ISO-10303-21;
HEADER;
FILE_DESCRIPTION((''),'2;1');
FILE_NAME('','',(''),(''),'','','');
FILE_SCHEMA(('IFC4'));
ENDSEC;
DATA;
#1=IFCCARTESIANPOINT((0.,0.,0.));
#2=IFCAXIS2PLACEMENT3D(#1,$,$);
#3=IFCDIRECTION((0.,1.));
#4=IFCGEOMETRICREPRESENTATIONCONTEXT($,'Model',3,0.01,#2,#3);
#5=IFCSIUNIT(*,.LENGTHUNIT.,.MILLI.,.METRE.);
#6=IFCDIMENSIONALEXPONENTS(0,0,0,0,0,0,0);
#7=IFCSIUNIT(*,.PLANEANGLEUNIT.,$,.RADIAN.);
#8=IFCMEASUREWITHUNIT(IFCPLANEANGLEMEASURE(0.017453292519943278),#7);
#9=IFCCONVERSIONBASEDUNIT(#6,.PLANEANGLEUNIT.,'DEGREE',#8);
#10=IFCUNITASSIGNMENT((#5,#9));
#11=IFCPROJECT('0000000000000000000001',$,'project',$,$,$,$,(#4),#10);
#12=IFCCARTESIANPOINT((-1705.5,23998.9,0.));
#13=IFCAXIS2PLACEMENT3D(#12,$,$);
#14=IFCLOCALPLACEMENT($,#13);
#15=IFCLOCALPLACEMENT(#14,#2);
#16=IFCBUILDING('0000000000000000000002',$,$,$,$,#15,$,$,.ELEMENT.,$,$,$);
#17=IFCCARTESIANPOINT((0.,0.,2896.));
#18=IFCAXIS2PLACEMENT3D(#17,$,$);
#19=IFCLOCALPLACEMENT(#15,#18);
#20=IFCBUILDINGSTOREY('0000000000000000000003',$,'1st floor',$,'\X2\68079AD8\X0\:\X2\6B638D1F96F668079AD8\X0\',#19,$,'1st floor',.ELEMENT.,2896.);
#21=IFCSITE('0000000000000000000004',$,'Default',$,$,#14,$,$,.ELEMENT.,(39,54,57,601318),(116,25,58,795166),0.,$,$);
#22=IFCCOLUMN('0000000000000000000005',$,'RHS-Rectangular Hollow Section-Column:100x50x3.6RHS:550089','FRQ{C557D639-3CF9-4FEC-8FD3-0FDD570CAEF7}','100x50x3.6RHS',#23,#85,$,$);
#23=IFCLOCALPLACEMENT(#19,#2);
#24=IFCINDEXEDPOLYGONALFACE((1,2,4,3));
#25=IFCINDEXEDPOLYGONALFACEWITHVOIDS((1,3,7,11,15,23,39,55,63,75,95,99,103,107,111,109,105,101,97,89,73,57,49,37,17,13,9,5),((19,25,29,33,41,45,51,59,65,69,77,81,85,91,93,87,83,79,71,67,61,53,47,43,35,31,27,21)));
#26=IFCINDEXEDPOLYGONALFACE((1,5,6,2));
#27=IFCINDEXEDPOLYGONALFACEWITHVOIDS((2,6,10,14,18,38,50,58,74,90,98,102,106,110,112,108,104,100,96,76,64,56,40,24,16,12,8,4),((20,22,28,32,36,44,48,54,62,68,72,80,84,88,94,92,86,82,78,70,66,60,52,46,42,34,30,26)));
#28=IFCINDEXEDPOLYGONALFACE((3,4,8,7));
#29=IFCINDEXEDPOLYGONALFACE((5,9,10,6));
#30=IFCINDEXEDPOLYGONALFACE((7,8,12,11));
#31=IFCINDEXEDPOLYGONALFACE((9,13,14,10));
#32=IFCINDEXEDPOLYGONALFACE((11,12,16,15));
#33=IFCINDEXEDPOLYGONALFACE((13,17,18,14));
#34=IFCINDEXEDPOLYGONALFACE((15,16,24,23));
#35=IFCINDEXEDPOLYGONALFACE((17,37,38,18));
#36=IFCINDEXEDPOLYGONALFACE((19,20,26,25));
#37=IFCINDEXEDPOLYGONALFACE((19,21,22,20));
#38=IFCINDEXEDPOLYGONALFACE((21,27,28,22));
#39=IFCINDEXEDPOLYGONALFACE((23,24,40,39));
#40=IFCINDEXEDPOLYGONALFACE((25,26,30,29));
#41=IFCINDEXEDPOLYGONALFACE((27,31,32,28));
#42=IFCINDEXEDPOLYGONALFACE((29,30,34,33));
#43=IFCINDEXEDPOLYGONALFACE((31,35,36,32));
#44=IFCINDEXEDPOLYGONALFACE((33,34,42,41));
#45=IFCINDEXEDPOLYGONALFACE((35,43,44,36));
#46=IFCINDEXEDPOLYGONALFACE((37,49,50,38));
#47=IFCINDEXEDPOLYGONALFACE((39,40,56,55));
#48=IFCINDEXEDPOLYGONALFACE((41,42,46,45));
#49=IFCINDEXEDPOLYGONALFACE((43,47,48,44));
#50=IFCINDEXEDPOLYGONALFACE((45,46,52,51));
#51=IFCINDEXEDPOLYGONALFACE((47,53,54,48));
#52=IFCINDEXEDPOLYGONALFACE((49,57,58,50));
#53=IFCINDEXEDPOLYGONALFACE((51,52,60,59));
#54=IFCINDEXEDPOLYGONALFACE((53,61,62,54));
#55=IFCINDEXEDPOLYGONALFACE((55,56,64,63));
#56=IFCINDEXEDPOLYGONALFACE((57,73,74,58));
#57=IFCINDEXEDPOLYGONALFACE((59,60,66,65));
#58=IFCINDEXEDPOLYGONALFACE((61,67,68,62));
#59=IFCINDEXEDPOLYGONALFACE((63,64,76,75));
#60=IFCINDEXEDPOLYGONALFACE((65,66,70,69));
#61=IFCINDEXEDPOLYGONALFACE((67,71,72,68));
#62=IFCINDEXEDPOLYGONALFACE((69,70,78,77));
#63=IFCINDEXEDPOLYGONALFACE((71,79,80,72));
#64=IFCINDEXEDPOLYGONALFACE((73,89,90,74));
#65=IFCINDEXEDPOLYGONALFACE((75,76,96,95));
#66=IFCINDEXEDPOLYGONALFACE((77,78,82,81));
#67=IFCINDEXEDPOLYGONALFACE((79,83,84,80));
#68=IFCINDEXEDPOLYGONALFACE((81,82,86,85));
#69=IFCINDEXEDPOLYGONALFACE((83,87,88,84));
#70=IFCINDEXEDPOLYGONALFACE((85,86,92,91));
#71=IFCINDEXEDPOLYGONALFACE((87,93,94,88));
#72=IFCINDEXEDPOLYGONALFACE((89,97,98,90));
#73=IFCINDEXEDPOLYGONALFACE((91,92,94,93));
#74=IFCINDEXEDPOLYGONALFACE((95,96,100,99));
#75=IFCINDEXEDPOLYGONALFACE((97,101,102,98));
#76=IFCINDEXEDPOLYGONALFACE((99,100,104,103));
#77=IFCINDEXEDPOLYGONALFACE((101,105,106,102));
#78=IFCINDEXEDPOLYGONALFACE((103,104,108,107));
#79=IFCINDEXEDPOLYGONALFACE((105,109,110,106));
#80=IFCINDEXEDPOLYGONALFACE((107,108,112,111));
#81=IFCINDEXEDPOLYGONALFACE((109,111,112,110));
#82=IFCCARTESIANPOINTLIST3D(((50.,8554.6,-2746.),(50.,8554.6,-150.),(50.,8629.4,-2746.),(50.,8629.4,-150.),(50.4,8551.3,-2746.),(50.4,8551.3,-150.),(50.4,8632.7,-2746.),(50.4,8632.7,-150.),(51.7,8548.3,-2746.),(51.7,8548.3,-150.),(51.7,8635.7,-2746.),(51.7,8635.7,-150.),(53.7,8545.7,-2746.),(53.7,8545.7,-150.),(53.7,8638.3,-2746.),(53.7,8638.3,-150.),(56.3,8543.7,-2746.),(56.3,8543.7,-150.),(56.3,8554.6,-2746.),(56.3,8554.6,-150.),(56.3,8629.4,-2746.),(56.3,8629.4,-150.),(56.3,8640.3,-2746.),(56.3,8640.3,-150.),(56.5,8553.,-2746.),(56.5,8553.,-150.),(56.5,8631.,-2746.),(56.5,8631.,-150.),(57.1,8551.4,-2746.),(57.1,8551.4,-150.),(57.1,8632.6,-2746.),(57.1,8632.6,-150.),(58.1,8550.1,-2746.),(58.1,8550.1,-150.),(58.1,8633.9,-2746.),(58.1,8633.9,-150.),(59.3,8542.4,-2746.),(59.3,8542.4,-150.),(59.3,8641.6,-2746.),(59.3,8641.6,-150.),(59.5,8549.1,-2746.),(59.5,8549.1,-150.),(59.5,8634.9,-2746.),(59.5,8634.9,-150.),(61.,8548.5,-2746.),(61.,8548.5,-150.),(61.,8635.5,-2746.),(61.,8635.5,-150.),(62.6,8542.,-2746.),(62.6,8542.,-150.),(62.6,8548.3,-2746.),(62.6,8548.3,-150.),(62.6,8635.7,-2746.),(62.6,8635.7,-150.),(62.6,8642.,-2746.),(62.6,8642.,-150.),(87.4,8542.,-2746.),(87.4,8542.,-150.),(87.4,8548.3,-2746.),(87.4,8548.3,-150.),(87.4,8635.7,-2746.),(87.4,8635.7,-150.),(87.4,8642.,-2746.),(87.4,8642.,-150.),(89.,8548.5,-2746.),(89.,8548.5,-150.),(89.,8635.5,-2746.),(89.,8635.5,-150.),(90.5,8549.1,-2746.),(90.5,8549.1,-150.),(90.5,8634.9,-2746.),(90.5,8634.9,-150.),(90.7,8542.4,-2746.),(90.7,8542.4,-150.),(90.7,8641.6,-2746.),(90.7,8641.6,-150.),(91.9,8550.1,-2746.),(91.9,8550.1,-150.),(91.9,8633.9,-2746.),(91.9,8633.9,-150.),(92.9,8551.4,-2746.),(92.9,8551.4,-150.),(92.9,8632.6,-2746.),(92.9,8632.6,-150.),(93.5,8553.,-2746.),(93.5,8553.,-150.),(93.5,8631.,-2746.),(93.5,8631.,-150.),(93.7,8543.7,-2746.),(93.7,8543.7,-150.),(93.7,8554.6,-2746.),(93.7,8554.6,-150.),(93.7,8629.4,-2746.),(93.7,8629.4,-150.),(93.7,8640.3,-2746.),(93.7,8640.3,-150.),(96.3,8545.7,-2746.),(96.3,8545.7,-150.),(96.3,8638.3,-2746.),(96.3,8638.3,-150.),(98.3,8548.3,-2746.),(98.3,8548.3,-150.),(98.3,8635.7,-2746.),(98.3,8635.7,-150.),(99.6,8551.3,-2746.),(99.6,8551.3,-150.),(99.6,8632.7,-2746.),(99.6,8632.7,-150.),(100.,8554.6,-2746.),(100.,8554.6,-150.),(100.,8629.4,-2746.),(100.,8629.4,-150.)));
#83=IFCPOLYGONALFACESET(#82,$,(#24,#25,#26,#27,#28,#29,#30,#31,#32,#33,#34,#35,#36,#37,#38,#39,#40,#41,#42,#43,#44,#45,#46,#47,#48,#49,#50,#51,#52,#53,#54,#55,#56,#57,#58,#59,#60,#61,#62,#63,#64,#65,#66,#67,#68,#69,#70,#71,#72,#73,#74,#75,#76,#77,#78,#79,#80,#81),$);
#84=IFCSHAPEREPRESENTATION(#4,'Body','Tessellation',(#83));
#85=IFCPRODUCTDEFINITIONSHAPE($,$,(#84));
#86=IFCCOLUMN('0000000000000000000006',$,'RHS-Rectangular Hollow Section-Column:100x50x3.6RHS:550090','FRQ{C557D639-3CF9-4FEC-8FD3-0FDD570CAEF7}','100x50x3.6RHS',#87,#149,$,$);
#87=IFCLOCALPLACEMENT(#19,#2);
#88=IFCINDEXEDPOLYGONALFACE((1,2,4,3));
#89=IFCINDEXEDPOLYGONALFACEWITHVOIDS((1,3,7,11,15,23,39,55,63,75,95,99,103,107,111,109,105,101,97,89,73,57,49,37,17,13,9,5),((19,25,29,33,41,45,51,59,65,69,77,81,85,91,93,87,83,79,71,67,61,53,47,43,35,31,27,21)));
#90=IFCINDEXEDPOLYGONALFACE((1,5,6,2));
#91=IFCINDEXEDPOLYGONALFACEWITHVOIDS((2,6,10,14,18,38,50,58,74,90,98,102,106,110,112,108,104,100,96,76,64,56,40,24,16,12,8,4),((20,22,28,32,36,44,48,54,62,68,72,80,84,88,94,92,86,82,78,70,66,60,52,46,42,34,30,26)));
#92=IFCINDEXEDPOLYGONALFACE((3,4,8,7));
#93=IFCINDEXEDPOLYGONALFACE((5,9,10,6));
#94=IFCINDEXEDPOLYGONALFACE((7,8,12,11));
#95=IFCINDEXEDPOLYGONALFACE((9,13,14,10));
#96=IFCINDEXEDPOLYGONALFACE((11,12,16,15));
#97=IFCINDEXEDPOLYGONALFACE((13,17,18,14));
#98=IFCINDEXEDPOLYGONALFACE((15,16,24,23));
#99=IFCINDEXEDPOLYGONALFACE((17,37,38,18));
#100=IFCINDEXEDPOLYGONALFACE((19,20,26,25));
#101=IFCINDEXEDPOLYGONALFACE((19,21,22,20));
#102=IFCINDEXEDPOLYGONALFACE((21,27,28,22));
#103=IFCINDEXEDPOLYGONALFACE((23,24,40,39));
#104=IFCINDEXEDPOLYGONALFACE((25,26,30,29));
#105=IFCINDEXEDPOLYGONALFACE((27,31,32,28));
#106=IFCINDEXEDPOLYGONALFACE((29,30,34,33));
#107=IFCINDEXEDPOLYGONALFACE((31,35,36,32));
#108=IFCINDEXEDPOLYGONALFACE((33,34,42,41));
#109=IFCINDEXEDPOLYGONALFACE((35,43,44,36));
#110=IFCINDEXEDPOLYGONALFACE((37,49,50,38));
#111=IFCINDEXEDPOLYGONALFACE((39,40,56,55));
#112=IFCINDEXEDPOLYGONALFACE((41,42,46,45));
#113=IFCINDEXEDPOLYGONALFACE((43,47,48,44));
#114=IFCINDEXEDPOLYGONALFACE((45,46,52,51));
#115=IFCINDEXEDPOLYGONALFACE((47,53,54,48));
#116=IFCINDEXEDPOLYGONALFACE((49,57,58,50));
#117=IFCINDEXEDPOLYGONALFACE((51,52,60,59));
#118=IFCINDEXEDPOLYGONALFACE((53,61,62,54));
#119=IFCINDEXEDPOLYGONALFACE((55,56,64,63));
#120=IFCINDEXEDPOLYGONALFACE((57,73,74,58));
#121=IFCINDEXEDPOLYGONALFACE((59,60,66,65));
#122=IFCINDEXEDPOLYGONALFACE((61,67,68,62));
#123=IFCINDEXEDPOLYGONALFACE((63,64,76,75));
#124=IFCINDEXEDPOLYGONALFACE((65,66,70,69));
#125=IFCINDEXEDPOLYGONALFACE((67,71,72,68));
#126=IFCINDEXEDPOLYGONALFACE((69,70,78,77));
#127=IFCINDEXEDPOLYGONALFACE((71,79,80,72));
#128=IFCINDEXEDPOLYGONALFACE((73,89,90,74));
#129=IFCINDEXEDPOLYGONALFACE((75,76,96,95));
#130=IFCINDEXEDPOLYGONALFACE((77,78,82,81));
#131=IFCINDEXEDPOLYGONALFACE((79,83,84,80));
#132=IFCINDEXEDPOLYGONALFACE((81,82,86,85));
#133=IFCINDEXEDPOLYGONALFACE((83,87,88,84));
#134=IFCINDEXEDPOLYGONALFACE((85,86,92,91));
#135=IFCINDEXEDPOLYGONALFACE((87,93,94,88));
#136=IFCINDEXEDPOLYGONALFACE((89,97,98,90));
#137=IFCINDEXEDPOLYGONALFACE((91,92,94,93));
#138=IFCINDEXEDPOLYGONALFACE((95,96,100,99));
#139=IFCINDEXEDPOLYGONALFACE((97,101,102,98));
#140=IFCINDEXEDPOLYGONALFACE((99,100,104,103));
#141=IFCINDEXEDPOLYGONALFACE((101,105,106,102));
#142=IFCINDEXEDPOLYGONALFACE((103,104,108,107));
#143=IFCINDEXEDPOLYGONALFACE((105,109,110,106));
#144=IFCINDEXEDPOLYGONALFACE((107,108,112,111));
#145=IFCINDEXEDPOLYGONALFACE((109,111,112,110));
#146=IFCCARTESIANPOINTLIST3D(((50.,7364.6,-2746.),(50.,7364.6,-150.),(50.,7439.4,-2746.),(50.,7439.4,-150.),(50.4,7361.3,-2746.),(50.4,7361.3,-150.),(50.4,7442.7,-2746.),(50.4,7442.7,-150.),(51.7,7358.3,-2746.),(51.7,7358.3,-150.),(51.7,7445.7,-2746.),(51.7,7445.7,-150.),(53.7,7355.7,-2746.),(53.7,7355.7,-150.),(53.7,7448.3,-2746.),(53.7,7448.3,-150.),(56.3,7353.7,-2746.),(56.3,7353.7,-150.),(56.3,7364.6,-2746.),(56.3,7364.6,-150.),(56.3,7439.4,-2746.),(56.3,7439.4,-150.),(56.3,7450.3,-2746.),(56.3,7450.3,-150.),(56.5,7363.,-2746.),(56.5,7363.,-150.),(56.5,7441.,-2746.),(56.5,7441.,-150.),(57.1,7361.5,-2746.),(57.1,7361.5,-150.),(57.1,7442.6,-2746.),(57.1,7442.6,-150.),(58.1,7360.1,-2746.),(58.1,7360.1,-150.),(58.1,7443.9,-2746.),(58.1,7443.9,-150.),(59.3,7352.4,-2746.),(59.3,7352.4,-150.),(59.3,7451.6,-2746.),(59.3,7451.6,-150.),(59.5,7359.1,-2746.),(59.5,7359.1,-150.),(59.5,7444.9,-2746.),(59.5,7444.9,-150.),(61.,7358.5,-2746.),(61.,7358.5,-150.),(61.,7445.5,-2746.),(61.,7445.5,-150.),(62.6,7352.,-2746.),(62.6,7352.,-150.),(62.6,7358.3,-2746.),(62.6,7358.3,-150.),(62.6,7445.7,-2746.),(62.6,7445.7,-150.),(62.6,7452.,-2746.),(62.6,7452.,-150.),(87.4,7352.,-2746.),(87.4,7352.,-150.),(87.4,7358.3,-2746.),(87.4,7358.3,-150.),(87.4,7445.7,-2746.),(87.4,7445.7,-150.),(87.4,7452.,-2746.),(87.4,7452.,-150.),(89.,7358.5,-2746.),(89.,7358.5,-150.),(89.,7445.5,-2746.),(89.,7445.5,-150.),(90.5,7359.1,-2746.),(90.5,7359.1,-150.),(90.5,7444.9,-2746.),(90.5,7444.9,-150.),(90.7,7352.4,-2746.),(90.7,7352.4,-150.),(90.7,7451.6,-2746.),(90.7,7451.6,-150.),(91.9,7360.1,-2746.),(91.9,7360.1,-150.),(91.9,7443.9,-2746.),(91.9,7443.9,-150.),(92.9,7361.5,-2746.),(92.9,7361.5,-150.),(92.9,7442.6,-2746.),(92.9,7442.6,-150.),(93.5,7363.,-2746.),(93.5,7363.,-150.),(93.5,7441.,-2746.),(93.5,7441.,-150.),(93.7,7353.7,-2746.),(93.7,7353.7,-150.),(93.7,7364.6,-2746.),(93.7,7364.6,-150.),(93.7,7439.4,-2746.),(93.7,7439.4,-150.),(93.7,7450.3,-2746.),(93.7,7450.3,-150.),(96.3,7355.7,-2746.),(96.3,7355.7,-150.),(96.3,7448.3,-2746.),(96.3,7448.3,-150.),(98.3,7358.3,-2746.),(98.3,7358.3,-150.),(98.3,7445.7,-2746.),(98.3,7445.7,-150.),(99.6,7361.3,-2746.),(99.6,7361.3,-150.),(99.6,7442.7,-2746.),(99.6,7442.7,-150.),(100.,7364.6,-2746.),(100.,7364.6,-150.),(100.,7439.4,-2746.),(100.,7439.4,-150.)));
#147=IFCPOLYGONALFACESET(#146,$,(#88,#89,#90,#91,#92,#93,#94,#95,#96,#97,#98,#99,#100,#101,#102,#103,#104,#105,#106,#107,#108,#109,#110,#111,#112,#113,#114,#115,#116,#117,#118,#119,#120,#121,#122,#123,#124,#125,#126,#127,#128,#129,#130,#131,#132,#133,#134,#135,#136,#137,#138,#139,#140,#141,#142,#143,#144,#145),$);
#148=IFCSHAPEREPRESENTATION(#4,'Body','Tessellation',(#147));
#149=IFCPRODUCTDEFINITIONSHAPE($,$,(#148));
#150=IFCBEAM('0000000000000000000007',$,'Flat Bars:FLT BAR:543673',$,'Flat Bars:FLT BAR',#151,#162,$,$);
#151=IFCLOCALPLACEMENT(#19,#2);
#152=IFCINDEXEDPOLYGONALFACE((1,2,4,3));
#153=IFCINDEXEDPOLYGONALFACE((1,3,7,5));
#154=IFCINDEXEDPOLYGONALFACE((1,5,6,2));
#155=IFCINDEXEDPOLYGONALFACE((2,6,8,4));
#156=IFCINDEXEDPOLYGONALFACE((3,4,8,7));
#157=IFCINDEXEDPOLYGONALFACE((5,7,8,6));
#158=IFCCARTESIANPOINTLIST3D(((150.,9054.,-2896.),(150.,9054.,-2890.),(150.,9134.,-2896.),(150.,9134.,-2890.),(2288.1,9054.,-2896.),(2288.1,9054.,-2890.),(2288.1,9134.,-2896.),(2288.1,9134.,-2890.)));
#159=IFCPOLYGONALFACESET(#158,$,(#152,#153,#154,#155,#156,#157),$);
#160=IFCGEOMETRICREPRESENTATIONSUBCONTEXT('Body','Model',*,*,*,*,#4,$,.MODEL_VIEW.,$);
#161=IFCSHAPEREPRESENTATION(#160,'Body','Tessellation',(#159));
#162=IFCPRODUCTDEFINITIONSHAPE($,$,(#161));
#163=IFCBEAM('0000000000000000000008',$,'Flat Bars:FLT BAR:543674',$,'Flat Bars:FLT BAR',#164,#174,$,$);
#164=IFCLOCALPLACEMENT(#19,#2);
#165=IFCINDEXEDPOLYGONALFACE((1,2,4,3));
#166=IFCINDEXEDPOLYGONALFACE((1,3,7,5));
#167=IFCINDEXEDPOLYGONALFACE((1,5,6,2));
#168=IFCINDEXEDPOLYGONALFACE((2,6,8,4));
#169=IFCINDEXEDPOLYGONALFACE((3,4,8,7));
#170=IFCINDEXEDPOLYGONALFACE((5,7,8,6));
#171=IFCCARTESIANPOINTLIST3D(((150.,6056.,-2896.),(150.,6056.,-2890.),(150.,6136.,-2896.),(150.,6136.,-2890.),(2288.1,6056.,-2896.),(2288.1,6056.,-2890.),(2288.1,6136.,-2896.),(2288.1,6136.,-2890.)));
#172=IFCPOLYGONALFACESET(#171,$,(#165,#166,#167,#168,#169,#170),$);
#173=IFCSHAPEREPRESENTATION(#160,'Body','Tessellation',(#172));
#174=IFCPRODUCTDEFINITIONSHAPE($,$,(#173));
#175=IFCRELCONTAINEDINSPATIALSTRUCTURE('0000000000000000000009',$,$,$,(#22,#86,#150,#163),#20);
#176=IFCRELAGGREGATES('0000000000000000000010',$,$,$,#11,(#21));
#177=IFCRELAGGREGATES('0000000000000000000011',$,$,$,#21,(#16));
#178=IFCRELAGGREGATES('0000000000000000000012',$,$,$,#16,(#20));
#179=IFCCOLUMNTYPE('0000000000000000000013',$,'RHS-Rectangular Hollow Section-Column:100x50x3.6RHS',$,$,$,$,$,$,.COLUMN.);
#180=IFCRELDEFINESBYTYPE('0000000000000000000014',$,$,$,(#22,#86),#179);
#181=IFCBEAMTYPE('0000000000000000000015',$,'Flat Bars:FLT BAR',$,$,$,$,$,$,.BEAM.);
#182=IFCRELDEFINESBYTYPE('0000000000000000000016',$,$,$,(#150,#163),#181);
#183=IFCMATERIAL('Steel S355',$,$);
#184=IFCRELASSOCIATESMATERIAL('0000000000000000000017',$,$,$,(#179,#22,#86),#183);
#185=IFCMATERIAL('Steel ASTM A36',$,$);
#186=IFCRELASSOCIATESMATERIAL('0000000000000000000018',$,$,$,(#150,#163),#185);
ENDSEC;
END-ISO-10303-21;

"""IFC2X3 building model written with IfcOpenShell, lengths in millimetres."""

from ifc_helpers import new_model, entity, si_unit, converted_unit, direction, frame, origin, origin_2d, origin_2d_with_axis, place, context, subcontext, project, spatial, rectangle, hollow_rectangle, extrude, clip, halfspace, material, type_object, element, save


model = new_model("IFC2X3")

# Units and contexts
model_context = context("Model", 3, precision=0.01, world=origin(), true_north=direction((0.0, 1.0)))
body_context = subcontext(model_context, "Body", "Model", "MODEL_VIEW")
ifc_project = project(units=[si_unit("LENGTHUNIT", "METRE", prefix="MILLI"), converted_unit("PLANEANGLEUNIT", "DEGREE", entity("IfcPlaneAngleMeasure", 0.017453292519943278), si_unit("PLANEANGLEUNIT", "RADIAN"), dimensions=[0, 0, 0, 0, 0, 0, 0])], contexts=[model_context])

# Site, building, storey
site_placement = place(None, frame((-1705.5, 23998.9, 0.0)))
site = spatial("IfcSite", under=ifc_project, at=site_placement, Name="Default", CompositionType="ELEMENT", RefLatitude=(39, 54, 57, 601318), RefLongitude=(116, 25, 58, 795166), RefElevation=0.0)
building_placement = place(site_placement, origin())
building = spatial("IfcBuilding", under=site, at=building_placement, CompositionType="ELEMENT")
storey_placement = place(building_placement, frame((0.0, 0.0, 2896.0)))
storey = spatial("IfcBuildingStorey", under=building, at=storey_placement, Name="1st floor", ObjectType="标高:正负零标高", LongName="1st floor", CompositionType="ELEMENT", Elevation=2896.0)

# Columns
ifc_material_1 = material(Name="Steel S355")
column_type = type_object("IfcColumnType", Name="RHS-Rectangular Hollow Section-Column:100x50x3.6RHS", PredefinedType="COLUMN", material=ifc_material_1)
column_1_placement = place(storey_placement, frame((75.0, 8592.0, -150.0), z_axis=(0.0, 0.0, 1.0), x_axis=(-1.0, 0.0, 0.0)))
element("IfcColumn", 1, at=column_1_placement, inside=storey, type_object=column_type, material=ifc_material_1, Name="RHS-Rectangular Hollow Section-Column:100x50x3.6RHS:550089", Description="FRQ{C557D639-3CF9-4FEC-8FD3-0FDD570CAEF7}", ObjectType="100x50x3.6RHS", context=model_context, shape_type="Clipping", body=[
    clip(extrude(hollow_rectangle(XDim=50.0, YDim=100.0, WallThickness=6.3, InnerFilletRadius=6.3, OuterFilletRadius=12.6, at=origin_2d()), origin(), (0.0, 0.0, -1.0), 2651.9), halfspace(frame((75.0, 8592.0, -2596.0), z_axis=(0.0, 0.0, 1.0), x_axis=(-1.0, 0.0, 0.0)), True)),
])
column_2_placement = place(storey_placement, frame((75.0, 7402.0, -150.0), z_axis=(0.0, 0.0, 1.0), x_axis=(-1.0, 0.0, 0.0)))
element("IfcColumn", 2, at=column_2_placement, inside=storey, type_object=column_type, material=ifc_material_1, Name="RHS-Rectangular Hollow Section-Column:100x50x3.6RHS:550090", Description="FRQ{C557D639-3CF9-4FEC-8FD3-0FDD570CAEF7}", ObjectType="100x50x3.6RHS", context=model_context, shape_type="Clipping", body=[
    clip(extrude(hollow_rectangle(XDim=50.0, YDim=100.0, WallThickness=6.3, InnerFilletRadius=6.3, OuterFilletRadius=12.6, at=origin_2d()), origin(), (0.0, 0.0, -1.0), 2651.9), halfspace(frame((75.0, 7402.0, -2596.0), z_axis=(0.0, 0.0, 1.0), x_axis=(-1.0, 0.0, 0.0)), True)),
])

# Beams
ifc_material_2 = material(Name="Steel ASTM A36")
beam_type_1 = type_object("IfcBeamType", Name="Flat Bars:FLT BAR", PredefinedType="BEAM")
for number, where, name in (
    (3, (150.0, 9094.0, -2890.0), "Flat Bars:FLT BAR:543673"),
    (4, (150.0, 6096.0, -2890.0), "Flat Bars:FLT BAR:543674"),
):
    element("IfcBeam", number, at=place(storey_placement, frame(where)), inside=storey, type_object=beam_type_1, material=ifc_material_2, Name=name, ObjectType="Flat Bars:FLT BAR", context=body_context, shape_type="SweptSolid", body=[
        extrude(rectangle(XDim=6.0, YDim=80.0, at=origin_2d_with_axis()), frame((0.0, 0.0, -3.0), z_axis=(1.0, 0.0, 0.0), x_axis=(0.0, 0.0, -1.0)), (0.0, 0.0, 1.0), 2138.1),
    ])

save(model, "model.ifc")
